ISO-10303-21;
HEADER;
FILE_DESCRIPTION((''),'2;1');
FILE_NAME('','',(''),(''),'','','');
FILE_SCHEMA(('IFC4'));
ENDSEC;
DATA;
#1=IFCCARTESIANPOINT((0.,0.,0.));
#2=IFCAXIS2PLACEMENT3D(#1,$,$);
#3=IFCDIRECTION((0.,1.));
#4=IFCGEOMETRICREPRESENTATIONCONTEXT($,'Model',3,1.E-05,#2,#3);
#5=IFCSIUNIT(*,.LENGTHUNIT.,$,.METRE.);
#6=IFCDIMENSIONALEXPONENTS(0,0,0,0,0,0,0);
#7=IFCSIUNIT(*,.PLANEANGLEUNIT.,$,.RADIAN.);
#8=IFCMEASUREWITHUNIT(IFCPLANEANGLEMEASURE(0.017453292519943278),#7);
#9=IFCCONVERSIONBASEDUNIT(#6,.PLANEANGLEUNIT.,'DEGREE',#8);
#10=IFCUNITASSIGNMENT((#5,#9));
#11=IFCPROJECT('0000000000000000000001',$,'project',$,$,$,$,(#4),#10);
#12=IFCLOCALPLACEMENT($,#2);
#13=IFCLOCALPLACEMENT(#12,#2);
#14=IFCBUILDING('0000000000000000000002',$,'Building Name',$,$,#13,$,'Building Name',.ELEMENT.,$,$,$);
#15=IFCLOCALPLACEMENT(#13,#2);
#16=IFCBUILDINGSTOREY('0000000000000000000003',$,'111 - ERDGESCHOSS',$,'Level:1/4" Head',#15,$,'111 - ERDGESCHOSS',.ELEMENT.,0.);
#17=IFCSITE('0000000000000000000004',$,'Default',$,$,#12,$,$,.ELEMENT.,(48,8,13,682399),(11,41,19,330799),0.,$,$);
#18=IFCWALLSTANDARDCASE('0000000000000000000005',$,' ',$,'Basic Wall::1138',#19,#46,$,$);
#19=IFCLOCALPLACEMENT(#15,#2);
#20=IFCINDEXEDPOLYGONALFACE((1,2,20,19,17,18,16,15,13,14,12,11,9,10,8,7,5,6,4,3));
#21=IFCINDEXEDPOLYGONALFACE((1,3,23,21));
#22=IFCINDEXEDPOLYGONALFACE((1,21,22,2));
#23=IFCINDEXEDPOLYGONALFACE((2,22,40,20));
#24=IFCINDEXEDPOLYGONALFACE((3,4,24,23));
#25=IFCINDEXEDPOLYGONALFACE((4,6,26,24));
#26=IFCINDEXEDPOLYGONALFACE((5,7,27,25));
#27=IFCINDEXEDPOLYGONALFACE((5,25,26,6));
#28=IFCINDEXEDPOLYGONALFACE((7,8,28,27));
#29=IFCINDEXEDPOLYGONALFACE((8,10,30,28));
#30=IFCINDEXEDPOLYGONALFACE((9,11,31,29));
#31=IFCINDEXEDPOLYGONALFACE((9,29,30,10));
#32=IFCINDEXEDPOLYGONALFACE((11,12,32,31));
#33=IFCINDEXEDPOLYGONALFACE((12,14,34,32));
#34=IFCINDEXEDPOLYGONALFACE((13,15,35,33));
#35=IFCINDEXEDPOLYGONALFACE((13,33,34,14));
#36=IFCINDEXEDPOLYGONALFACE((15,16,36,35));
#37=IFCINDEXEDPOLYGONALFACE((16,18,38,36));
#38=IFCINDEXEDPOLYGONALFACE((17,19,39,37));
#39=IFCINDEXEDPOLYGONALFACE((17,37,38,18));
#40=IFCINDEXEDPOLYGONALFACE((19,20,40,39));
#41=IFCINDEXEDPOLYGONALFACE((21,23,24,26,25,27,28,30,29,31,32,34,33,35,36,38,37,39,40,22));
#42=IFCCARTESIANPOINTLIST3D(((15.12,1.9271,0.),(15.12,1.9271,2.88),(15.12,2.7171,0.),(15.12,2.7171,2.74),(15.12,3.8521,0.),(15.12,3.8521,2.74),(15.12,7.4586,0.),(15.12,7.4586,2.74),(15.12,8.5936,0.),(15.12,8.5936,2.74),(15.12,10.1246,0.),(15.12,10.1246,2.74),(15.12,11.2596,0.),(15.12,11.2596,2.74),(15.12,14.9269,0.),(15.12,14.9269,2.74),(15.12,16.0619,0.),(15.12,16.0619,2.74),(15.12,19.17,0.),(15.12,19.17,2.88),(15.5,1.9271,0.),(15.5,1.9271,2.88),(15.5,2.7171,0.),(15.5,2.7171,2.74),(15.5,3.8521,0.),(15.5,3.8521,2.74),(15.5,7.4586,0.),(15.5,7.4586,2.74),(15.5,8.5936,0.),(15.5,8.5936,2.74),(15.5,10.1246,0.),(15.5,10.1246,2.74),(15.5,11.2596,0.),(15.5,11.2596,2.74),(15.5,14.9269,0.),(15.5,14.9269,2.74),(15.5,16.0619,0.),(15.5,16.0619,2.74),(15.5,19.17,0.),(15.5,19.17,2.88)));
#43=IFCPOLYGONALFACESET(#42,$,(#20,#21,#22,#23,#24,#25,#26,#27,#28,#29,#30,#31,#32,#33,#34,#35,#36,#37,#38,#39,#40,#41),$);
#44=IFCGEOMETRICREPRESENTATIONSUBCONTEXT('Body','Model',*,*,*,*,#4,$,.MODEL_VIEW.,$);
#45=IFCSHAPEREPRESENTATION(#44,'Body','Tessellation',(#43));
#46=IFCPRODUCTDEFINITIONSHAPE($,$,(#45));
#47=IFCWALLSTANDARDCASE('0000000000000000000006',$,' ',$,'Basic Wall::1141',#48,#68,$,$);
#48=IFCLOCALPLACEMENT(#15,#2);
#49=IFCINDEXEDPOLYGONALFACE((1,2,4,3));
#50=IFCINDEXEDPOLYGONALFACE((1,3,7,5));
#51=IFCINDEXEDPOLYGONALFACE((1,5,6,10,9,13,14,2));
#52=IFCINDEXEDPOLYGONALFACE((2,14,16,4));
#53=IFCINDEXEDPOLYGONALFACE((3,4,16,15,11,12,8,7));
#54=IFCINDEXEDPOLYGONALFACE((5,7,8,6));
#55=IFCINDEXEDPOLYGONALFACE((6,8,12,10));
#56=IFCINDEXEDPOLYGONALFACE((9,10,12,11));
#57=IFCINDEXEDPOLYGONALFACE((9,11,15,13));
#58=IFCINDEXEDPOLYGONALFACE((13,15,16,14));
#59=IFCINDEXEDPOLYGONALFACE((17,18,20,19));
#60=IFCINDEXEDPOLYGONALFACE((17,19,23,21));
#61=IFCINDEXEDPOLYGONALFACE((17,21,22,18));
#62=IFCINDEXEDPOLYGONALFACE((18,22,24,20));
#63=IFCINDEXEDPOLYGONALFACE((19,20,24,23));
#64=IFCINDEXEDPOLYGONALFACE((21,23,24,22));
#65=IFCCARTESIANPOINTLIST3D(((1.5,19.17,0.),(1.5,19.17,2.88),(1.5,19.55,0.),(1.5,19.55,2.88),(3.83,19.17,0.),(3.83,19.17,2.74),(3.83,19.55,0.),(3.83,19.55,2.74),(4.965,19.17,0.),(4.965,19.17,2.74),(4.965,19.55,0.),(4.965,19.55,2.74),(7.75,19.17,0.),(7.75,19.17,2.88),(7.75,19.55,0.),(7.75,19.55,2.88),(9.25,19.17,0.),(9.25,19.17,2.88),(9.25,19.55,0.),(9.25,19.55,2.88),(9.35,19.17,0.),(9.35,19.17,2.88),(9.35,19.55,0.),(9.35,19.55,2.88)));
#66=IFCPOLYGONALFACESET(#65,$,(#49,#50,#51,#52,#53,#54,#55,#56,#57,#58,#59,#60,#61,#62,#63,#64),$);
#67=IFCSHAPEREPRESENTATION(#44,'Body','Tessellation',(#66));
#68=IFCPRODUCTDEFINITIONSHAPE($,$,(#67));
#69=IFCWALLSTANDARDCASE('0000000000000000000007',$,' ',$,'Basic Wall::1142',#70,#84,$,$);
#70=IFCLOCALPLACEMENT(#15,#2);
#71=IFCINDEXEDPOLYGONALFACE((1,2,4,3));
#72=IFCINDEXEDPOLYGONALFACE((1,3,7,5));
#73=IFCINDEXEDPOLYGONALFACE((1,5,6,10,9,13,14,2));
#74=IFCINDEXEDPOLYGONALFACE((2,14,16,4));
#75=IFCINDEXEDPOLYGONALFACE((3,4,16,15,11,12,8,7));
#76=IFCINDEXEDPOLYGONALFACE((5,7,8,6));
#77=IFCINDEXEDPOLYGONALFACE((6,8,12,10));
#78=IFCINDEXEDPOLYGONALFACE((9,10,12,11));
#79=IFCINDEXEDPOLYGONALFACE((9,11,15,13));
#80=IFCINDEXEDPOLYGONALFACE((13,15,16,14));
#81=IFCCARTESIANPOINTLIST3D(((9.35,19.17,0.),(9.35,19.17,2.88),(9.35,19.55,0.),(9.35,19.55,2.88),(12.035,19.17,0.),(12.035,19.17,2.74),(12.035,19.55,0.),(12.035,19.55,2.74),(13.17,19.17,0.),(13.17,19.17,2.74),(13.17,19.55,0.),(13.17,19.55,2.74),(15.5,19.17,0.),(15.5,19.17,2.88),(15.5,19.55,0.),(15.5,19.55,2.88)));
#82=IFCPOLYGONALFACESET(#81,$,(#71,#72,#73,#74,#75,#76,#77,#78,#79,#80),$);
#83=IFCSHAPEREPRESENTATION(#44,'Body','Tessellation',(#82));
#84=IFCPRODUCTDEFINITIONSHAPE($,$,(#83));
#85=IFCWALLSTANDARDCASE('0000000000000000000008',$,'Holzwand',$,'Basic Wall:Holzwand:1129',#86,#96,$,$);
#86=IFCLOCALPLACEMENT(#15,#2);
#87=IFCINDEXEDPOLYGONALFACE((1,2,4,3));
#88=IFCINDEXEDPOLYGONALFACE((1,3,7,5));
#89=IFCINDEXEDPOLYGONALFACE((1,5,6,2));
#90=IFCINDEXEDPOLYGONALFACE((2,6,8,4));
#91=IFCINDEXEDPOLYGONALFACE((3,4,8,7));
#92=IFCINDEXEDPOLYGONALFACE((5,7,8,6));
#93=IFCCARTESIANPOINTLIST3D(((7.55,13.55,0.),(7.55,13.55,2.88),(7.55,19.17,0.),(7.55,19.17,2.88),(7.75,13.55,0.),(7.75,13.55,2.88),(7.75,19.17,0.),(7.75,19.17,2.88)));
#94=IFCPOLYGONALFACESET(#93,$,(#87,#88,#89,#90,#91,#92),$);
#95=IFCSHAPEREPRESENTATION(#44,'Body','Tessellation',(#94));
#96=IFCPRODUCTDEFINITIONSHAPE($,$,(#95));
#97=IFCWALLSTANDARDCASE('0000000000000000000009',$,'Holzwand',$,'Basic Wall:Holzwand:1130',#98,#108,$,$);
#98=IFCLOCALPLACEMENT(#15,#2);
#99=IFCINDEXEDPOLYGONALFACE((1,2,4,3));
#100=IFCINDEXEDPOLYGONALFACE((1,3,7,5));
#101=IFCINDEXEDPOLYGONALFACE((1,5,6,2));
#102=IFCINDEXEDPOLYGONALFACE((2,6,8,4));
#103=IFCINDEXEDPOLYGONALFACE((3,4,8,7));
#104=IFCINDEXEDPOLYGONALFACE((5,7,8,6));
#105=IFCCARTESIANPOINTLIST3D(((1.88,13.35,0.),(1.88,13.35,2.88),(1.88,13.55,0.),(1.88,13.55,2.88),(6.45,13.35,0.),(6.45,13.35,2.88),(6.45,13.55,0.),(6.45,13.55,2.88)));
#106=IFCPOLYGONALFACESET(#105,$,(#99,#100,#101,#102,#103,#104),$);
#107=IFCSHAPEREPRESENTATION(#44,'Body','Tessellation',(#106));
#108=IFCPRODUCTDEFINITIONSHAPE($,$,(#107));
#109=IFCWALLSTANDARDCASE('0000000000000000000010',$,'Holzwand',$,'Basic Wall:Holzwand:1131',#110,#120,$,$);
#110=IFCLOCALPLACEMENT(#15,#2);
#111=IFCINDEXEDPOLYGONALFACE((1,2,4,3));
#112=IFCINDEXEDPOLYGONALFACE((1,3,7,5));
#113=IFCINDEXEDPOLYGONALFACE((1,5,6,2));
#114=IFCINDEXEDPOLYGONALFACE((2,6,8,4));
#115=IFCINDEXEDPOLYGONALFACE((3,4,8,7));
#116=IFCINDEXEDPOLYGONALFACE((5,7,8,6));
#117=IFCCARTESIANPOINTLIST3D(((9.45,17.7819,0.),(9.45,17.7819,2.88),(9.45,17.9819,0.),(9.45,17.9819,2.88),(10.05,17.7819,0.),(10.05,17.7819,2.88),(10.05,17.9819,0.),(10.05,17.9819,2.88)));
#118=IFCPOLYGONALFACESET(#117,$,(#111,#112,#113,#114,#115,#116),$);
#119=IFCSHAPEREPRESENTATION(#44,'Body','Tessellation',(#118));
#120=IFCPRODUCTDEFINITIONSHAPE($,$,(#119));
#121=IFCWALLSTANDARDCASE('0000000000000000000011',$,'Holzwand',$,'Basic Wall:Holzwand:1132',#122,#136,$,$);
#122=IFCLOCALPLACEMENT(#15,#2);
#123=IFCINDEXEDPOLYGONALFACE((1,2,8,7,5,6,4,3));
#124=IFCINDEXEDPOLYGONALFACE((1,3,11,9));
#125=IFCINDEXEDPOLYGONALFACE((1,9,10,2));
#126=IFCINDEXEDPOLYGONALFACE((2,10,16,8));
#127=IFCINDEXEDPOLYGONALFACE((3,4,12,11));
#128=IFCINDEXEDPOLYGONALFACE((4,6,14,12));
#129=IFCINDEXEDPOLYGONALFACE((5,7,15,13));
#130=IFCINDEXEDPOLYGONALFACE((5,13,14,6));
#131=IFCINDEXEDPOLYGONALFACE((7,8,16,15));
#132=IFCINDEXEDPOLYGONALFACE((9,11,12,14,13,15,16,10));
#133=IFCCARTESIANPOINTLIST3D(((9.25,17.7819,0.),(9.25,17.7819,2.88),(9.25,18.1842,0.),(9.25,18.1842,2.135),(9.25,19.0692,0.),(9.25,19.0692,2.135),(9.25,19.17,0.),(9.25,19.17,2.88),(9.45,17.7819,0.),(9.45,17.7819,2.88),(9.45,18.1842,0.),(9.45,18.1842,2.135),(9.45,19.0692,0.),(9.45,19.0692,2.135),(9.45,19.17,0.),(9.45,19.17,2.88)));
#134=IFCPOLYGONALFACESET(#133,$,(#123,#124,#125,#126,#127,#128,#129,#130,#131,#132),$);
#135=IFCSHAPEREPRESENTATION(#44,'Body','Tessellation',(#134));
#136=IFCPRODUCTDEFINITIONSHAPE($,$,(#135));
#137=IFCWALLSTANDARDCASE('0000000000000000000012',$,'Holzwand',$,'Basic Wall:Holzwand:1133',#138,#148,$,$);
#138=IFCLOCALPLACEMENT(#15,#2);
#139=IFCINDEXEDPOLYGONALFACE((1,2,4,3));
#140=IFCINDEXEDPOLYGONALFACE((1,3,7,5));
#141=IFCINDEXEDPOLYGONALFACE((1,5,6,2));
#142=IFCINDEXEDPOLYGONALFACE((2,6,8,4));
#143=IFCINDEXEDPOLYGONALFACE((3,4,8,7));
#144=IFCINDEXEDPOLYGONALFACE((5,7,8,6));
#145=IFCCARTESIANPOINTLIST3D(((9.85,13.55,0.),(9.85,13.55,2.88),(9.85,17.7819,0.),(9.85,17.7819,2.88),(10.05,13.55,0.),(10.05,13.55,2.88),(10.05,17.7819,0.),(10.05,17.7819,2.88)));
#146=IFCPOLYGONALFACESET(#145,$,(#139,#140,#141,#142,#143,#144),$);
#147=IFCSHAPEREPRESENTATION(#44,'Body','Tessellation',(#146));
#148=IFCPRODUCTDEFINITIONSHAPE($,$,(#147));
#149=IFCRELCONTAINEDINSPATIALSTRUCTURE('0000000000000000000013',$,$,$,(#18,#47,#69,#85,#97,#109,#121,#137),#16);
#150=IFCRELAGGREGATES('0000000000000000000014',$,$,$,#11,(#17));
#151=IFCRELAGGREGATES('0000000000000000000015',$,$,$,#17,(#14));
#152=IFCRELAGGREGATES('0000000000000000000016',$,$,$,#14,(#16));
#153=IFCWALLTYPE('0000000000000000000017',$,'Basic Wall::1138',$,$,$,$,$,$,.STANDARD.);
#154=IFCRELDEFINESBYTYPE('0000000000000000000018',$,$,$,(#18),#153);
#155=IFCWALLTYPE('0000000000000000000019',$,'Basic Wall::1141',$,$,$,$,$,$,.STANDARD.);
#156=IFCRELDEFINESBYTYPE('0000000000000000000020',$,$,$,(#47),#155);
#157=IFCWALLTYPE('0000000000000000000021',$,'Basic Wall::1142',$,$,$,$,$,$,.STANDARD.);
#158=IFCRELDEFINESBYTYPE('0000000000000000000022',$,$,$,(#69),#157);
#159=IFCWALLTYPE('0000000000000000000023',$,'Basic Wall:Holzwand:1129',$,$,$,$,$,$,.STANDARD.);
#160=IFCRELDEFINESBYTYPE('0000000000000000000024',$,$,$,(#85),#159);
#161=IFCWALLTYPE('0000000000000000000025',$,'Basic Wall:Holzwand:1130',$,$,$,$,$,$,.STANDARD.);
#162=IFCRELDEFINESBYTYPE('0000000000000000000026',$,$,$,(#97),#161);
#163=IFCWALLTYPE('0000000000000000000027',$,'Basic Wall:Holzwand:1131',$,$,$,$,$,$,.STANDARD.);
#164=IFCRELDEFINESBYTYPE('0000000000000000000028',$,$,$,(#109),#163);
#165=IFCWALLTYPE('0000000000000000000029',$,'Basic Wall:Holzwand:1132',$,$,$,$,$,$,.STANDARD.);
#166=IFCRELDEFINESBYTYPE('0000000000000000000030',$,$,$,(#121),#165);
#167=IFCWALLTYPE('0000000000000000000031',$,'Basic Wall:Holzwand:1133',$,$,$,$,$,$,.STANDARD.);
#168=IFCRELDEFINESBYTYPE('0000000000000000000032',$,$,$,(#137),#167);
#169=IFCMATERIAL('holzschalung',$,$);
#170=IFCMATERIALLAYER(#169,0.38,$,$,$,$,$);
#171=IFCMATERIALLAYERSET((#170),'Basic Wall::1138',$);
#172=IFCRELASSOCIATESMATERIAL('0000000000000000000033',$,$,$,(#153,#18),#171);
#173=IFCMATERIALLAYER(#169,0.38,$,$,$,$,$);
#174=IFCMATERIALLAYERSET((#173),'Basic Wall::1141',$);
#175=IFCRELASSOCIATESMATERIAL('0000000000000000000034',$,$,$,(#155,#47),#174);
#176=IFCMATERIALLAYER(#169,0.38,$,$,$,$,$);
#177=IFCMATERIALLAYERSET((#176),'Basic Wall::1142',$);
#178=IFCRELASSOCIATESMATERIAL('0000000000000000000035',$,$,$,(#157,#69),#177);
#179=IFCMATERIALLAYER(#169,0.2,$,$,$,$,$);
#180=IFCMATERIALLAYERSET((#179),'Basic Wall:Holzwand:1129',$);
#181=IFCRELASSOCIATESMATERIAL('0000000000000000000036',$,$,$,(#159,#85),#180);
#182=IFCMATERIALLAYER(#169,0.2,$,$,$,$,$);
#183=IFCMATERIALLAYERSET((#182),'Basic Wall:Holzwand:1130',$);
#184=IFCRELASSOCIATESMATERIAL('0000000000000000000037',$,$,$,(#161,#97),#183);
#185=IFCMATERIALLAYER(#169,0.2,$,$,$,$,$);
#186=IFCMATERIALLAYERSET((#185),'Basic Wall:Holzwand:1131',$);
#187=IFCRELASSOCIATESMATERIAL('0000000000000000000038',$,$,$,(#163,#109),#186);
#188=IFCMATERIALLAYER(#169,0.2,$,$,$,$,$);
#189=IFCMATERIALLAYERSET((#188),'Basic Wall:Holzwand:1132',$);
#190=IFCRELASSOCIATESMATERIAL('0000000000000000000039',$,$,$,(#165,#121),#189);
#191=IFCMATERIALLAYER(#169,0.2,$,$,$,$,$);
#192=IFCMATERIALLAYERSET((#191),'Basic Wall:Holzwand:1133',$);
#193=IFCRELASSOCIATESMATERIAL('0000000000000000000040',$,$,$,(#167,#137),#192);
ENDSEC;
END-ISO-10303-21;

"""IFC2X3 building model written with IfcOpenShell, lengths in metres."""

from ifc_helpers import new_model, entity, si_unit, converted_unit, direction, frame, frame_2d, origin, origin_2d_with_axis, place, context, subcontext, project, spatial, rectangle, extrude, material, layer, layer_set, layer_usage, type_object, element, save


model = new_model("IFC2X3")

# Units and contexts
model_context = context("Model", 3, precision=1e-05, world=origin(), true_north=direction((0.0, 1.0)))
body_context = subcontext(model_context, "Body", "Model", "MODEL_VIEW")
ifc_project = project(units=[si_unit("LENGTHUNIT", "METRE"), converted_unit("PLANEANGLEUNIT", "DEGREE", entity("IfcPlaneAngleMeasure", 0.017453292519943278), si_unit("PLANEANGLEUNIT", "RADIAN"), dimensions=[0, 0, 0, 0, 0, 0, 0])], contexts=[model_context])

# Site, building, storey
site_placement = place(None, origin())
site = spatial("IfcSite", under=ifc_project, at=site_placement, Name="Default", CompositionType="ELEMENT", RefLatitude=(48, 8, 13, 682399), RefLongitude=(11, 41, 19, 330799), RefElevation=0.0)
building_placement = place(site_placement, origin())
building = spatial("IfcBuilding", under=site, at=building_placement, Name="Building Name", LongName="Building Name", CompositionType="ELEMENT")
storey_placement = place(building_placement, origin())
storey = spatial("IfcBuildingStorey", under=building, at=storey_placement, Name="111 - ERDGESCHOSS", ObjectType="Level:1/4\" Head", LongName="111 - ERDGESCHOSS", CompositionType="ELEMENT", Elevation=0.0)

# Walls, openings
ifc_material_1 = material(Name="holzschalung")
ifc_layer_1 = layer(ifc_material_1, 0.38)
ifc_layer_set_1 = layer_set([ifc_layer_1], Name="Basic Wall::1138")
ifc_layer_usage_1 = layer_usage(ifc_layer_set_1, "AXIS2", "NEGATIVE", 0.19)
wall_type_1 = type_object("IfcWallType", Name="Basic Wall::1138", PredefinedType="STANDARD", material=ifc_layer_set_1)
wall_1_placement = place(storey_placement, frame((15.31, 19.17, 0.0), z_axis=(0.0, 0.0, 1.0), x_axis=(0.0, -1.0, 0.0)))
wall_1 = element("IfcWallStandardCase", 1, at=wall_1_placement, inside=storey, type_object=wall_type_1, material=ifc_layer_usage_1, Name=" ", ObjectType="Basic Wall::1138", context=body_context, shape_type="SweptSolid", body=[
    extrude(rectangle(XDim=17.2429, YDim=0.38, at=frame_2d((8.6214, 0.0), x_axis=(1.0, 0.0))), origin(), (0.0, 0.0, 1.0), 2.88),
])
opening_1_placement = place(wall_1_placement, origin())
element("IfcOpeningElement", 2, at=opening_1_placement, cuts=wall_1, ObjectType="Opening", context=body_context, shape_type="SweptSolid", body=[
    extrude(rectangle(XDim=2.74, YDim=1.135, at=frame_2d((0.0, 0.0), x_axis=(0.0, 1.0))), frame((15.8854, -0.19, 1.37), z_axis=(0.0, 1.0, 0.0), x_axis=(-1.0, 0.0, 0.0)), (0.0, 0.0, 1.0), 0.38),
])
opening_2_placement = place(wall_1_placement, origin())
element("IfcOpeningElement", 3, at=opening_2_placement, cuts=wall_1, ObjectType="Opening", context=body_context, shape_type="SweptSolid", body=[
    extrude(rectangle(XDim=2.74, YDim=1.135, at=frame_2d((0.0, 0.0), x_axis=(0.0, 1.0))), frame((11.1439, -0.19, 1.37), z_axis=(0.0, 1.0, 0.0), x_axis=(-1.0, 0.0, 0.0)), (0.0, 0.0, 1.0), 0.38),
])
opening_3_placement = place(wall_1_placement, origin())
element("IfcOpeningElement", 4, at=opening_3_placement, cuts=wall_1, ObjectType="Opening", context=body_context, shape_type="SweptSolid", body=[
    extrude(rectangle(XDim=2.74, YDim=1.135, at=frame_2d((0.0, 0.0), x_axis=(0.0, 1.0))), frame((8.4779, -0.19, 1.37), z_axis=(0.0, 1.0, 0.0), x_axis=(-1.0, 0.0, 0.0)), (0.0, 0.0, 1.0), 0.38),
])
opening_4_placement = place(wall_1_placement, origin())
element("IfcOpeningElement", 5, at=opening_4_placement, cuts=wall_1, ObjectType="Opening", context=body_context, shape_type="SweptSolid", body=[
    extrude(rectangle(XDim=2.74, YDim=1.135, at=frame_2d((0.0, 0.0), x_axis=(0.0, 1.0))), frame((3.6756, -0.19, 1.37), z_axis=(0.0, 1.0, 0.0), x_axis=(-1.0, 0.0, 0.0)), (0.0, 0.0, 1.0), 0.38),
])
ifc_layer_2 = layer(ifc_material_1, 0.38)
ifc_layer_set_2 = layer_set([ifc_layer_2], Name="Basic Wall::1141")
ifc_layer_usage_2 = layer_usage(ifc_layer_set_2, "AXIS2", "NEGATIVE", 0.19)
wall_type_2 = type_object("IfcWallType", Name="Basic Wall::1141", PredefinedType="STANDARD", material=ifc_layer_set_2)
wall_2_placement = place(storey_placement, frame((1.5, 19.36, 0.0)))
wall_2 = element("IfcWallStandardCase", 6, at=wall_2_placement, inside=storey, type_object=wall_type_2, material=ifc_layer_usage_2, Name=" ", ObjectType="Basic Wall::1141", context=body_context, shape_type="SweptSolid", body=[
    extrude(rectangle(XDim=7.85, YDim=0.38, at=frame_2d((3.925, 0.0), x_axis=(-1.0, 0.0))), origin(), (0.0, 0.0, 1.0), 2.88),
])
opening_5_placement = place(wall_2_placement, origin())
element("IfcOpeningElement", 7, at=opening_5_placement, cuts=wall_2, ObjectType="Opening", context=body_context, shape_type="SweptSolid", body=[
    extrude(rectangle(XDim=2.74, YDim=1.135, at=frame_2d((0.0, 0.0), x_axis=(1.0, 0.0))), frame((2.8975, -0.19, 1.37), z_axis=(0.0, 1.0, 0.0), x_axis=(0.0, 0.0, 1.0)), (0.0, 0.0, 1.0), 0.38),
])
opening_6_placement = place(wall_2_placement, frame((-1.5, -19.36, 0.0)))
element("IfcOpeningElement", 8, at=opening_6_placement, cuts=wall_2, ObjectType="Opening", context=body_context, shape_type="SweptSolid", body=[
    extrude(rectangle(XDim=3.03, YDim=1.5, at=frame_2d((0.0, 0.0), x_axis=(0.0, 1.0))), frame((8.5, 19.1662, 1.365), z_axis=(0.0, 1.0, 0.0), x_axis=(-1.0, 0.0, 0.0)), (0.0, 0.0, 1.0), 0.3876),
])

# Wall, opening
ifc_layer_3 = layer(ifc_material_1, 0.38)
ifc_layer_set_3 = layer_set([ifc_layer_3], Name="Basic Wall::1142")
ifc_layer_usage_3 = layer_usage(ifc_layer_set_3, "AXIS2", "NEGATIVE", 0.19)
wall_type_3 = type_object("IfcWallType", Name="Basic Wall::1142", PredefinedType="STANDARD", material=ifc_layer_set_3)
wall_3_placement = place(storey_placement, frame((9.35, 19.36, 0.0)))
wall_3 = element("IfcWallStandardCase", 9, at=wall_3_placement, inside=storey, type_object=wall_type_3, material=ifc_layer_usage_3, Name=" ", ObjectType="Basic Wall::1142", context=body_context, shape_type="SweptSolid", body=[
    extrude(rectangle(XDim=6.15, YDim=0.38, at=frame_2d((3.075, 0.0), x_axis=(-1.0, 0.0))), origin(), (0.0, 0.0, 1.0), 2.88),
])
opening_7_placement = place(wall_3_placement, origin())
element("IfcOpeningElement", 10, at=opening_7_placement, cuts=wall_3, ObjectType="Opening", context=body_context, shape_type="SweptSolid", body=[
    extrude(rectangle(XDim=2.74, YDim=1.135, at=origin_2d_with_axis()), frame((3.2525, -0.19, 1.37), z_axis=(0.0, 1.0, 0.0), x_axis=(0.0, 0.0, 1.0)), (0.0, 0.0, 1.0), 0.38),
])

# Walls
ifc_layer_4 = layer(ifc_material_1, 0.2)
ifc_layer_set_4 = layer_set([ifc_layer_4], Name="Basic Wall:Holzwand:1129")
ifc_layer_usage_4 = layer_usage(ifc_layer_set_4, "AXIS2", "NEGATIVE", 0.1)
wall_type_4 = type_object("IfcWallType", Name="Basic Wall:Holzwand:1129", PredefinedType="STANDARD", material=ifc_layer_set_4)
wall_4_placement = place(storey_placement, frame((7.65, 13.55, 0.0), z_axis=(0.0, 0.0, 1.0), x_axis=(0.0, 1.0, 0.0)))
element("IfcWallStandardCase", 11, at=wall_4_placement, inside=storey, type_object=wall_type_4, material=ifc_layer_usage_4, Name="Holzwand", ObjectType="Basic Wall:Holzwand:1129", context=body_context, shape_type="SweptSolid", body=[
    extrude(rectangle(XDim=5.62, YDim=0.2, at=frame_2d((2.81, 0.0), x_axis=(-1.0, 0.0))), origin(), (0.0, 0.0, 1.0), 2.88),
])
ifc_layer_5 = layer(ifc_material_1, 0.2)
ifc_layer_set_5 = layer_set([ifc_layer_5], Name="Basic Wall:Holzwand:1130")
ifc_layer_usage_5 = layer_usage(ifc_layer_set_5, "AXIS2", "NEGATIVE", 0.1)
wall_type_5 = type_object("IfcWallType", Name="Basic Wall:Holzwand:1130", PredefinedType="STANDARD", material=ifc_layer_set_5)
wall_5_placement = place(storey_placement, frame((1.88, 13.45, 0.0)))
element("IfcWallStandardCase", 12, at=wall_5_placement, inside=storey, type_object=wall_type_5, material=ifc_layer_usage_5, Name="Holzwand", ObjectType="Basic Wall:Holzwand:1130", context=body_context, shape_type="SweptSolid", body=[
    extrude(rectangle(XDim=4.57, YDim=0.2, at=frame_2d((2.285, 0.0), x_axis=(-1.0, 0.0))), origin(), (0.0, 0.0, 1.0), 2.88),
])
ifc_layer_6 = layer(ifc_material_1, 0.2)
ifc_layer_set_6 = layer_set([ifc_layer_6], Name="Basic Wall:Holzwand:1131")
ifc_layer_usage_6 = layer_usage(ifc_layer_set_6, "AXIS2", "NEGATIVE", 0.1)
wall_type_6 = type_object("IfcWallType", Name="Basic Wall:Holzwand:1131", PredefinedType="STANDARD", material=ifc_layer_set_6)
wall_6_placement = place(storey_placement, frame((10.05, 17.8819, 0.0), z_axis=(0.0, 0.0, 1.0), x_axis=(-1.0, 0.0, 0.0)))
element("IfcWallStandardCase", 13, at=wall_6_placement, inside=storey, type_object=wall_type_6, material=ifc_layer_usage_6, Name="Holzwand", ObjectType="Basic Wall:Holzwand:1131", context=body_context, shape_type="SweptSolid", body=[
    extrude(rectangle(XDim=0.6, YDim=0.2, at=frame_2d((0.3, 0.0), x_axis=(-1.0, 0.0))), origin(), (0.0, 0.0, 1.0), 2.88),
])

# Wall, opening
ifc_layer_7 = layer(ifc_material_1, 0.2)
ifc_layer_set_7 = layer_set([ifc_layer_7], Name="Basic Wall:Holzwand:1132")
ifc_layer_usage_7 = layer_usage(ifc_layer_set_7, "AXIS2", "NEGATIVE", 0.1)
wall_type_7 = type_object("IfcWallType", Name="Basic Wall:Holzwand:1132", PredefinedType="STANDARD", material=ifc_layer_set_7)
wall_7_placement = place(storey_placement, frame((9.35, 17.7819, 0.0), z_axis=(0.0, 0.0, 1.0), x_axis=(0.0, 1.0, 0.0)))
wall_7 = element("IfcWallStandardCase", 14, at=wall_7_placement, inside=storey, type_object=wall_type_7, material=ifc_layer_usage_7, Name="Holzwand", ObjectType="Basic Wall:Holzwand:1132", context=body_context, shape_type="SweptSolid", body=[
    extrude(rectangle(XDim=1.3881, YDim=0.2, at=frame_2d((0.6941, 0.0), x_axis=(-1.0, 0.0))), origin(), (0.0, 0.0, 1.0), 2.88),
])
opening_8_placement = place(wall_7_placement, frame((-17.7819, 9.35, 0.0), z_axis=(0.0, 0.0, 1.0), x_axis=(0.0, -1.0, 0.0)))
element("IfcOpeningElement", 15, at=opening_8_placement, cuts=wall_7, ObjectType="Opening", context=body_context, shape_type="SweptSolid", body=[
    extrude(rectangle(XDim=2.135, YDim=0.885, at=frame_2d((0.0, 0.0), x_axis=(1.0, 0.0))), frame((9.452, 18.6267, 1.0675), z_axis=(-1.0, 0.0, 0.0), x_axis=(0.0, 0.0, 1.0)), (0.0, 0.0, 1.0), 0.204),
])

# Wall
ifc_layer_8 = layer(ifc_material_1, 0.2)
ifc_layer_set_8 = layer_set([ifc_layer_8], Name="Basic Wall:Holzwand:1133")
ifc_layer_usage_8 = layer_usage(ifc_layer_set_8, "AXIS2", "NEGATIVE", 0.1)
wall_type_8 = type_object("IfcWallType", Name="Basic Wall:Holzwand:1133", PredefinedType="STANDARD", material=ifc_layer_set_8)
wall_8_placement = place(storey_placement, frame((9.95, 13.55, 0.0), z_axis=(0.0, 0.0, 1.0), x_axis=(0.0, 1.0, 0.0)))
element("IfcWallStandardCase", 16, at=wall_8_placement, inside=storey, type_object=wall_type_8, material=ifc_layer_usage_8, Name="Holzwand", ObjectType="Basic Wall:Holzwand:1133", context=body_context, shape_type="SweptSolid", body=[
    extrude(rectangle(XDim=4.2319, YDim=0.2, at=frame_2d((2.1159, 0.0), x_axis=(-1.0, 0.0))), origin(), (0.0, 0.0, 1.0), 2.88),
])

save(model, "model.ifc")
